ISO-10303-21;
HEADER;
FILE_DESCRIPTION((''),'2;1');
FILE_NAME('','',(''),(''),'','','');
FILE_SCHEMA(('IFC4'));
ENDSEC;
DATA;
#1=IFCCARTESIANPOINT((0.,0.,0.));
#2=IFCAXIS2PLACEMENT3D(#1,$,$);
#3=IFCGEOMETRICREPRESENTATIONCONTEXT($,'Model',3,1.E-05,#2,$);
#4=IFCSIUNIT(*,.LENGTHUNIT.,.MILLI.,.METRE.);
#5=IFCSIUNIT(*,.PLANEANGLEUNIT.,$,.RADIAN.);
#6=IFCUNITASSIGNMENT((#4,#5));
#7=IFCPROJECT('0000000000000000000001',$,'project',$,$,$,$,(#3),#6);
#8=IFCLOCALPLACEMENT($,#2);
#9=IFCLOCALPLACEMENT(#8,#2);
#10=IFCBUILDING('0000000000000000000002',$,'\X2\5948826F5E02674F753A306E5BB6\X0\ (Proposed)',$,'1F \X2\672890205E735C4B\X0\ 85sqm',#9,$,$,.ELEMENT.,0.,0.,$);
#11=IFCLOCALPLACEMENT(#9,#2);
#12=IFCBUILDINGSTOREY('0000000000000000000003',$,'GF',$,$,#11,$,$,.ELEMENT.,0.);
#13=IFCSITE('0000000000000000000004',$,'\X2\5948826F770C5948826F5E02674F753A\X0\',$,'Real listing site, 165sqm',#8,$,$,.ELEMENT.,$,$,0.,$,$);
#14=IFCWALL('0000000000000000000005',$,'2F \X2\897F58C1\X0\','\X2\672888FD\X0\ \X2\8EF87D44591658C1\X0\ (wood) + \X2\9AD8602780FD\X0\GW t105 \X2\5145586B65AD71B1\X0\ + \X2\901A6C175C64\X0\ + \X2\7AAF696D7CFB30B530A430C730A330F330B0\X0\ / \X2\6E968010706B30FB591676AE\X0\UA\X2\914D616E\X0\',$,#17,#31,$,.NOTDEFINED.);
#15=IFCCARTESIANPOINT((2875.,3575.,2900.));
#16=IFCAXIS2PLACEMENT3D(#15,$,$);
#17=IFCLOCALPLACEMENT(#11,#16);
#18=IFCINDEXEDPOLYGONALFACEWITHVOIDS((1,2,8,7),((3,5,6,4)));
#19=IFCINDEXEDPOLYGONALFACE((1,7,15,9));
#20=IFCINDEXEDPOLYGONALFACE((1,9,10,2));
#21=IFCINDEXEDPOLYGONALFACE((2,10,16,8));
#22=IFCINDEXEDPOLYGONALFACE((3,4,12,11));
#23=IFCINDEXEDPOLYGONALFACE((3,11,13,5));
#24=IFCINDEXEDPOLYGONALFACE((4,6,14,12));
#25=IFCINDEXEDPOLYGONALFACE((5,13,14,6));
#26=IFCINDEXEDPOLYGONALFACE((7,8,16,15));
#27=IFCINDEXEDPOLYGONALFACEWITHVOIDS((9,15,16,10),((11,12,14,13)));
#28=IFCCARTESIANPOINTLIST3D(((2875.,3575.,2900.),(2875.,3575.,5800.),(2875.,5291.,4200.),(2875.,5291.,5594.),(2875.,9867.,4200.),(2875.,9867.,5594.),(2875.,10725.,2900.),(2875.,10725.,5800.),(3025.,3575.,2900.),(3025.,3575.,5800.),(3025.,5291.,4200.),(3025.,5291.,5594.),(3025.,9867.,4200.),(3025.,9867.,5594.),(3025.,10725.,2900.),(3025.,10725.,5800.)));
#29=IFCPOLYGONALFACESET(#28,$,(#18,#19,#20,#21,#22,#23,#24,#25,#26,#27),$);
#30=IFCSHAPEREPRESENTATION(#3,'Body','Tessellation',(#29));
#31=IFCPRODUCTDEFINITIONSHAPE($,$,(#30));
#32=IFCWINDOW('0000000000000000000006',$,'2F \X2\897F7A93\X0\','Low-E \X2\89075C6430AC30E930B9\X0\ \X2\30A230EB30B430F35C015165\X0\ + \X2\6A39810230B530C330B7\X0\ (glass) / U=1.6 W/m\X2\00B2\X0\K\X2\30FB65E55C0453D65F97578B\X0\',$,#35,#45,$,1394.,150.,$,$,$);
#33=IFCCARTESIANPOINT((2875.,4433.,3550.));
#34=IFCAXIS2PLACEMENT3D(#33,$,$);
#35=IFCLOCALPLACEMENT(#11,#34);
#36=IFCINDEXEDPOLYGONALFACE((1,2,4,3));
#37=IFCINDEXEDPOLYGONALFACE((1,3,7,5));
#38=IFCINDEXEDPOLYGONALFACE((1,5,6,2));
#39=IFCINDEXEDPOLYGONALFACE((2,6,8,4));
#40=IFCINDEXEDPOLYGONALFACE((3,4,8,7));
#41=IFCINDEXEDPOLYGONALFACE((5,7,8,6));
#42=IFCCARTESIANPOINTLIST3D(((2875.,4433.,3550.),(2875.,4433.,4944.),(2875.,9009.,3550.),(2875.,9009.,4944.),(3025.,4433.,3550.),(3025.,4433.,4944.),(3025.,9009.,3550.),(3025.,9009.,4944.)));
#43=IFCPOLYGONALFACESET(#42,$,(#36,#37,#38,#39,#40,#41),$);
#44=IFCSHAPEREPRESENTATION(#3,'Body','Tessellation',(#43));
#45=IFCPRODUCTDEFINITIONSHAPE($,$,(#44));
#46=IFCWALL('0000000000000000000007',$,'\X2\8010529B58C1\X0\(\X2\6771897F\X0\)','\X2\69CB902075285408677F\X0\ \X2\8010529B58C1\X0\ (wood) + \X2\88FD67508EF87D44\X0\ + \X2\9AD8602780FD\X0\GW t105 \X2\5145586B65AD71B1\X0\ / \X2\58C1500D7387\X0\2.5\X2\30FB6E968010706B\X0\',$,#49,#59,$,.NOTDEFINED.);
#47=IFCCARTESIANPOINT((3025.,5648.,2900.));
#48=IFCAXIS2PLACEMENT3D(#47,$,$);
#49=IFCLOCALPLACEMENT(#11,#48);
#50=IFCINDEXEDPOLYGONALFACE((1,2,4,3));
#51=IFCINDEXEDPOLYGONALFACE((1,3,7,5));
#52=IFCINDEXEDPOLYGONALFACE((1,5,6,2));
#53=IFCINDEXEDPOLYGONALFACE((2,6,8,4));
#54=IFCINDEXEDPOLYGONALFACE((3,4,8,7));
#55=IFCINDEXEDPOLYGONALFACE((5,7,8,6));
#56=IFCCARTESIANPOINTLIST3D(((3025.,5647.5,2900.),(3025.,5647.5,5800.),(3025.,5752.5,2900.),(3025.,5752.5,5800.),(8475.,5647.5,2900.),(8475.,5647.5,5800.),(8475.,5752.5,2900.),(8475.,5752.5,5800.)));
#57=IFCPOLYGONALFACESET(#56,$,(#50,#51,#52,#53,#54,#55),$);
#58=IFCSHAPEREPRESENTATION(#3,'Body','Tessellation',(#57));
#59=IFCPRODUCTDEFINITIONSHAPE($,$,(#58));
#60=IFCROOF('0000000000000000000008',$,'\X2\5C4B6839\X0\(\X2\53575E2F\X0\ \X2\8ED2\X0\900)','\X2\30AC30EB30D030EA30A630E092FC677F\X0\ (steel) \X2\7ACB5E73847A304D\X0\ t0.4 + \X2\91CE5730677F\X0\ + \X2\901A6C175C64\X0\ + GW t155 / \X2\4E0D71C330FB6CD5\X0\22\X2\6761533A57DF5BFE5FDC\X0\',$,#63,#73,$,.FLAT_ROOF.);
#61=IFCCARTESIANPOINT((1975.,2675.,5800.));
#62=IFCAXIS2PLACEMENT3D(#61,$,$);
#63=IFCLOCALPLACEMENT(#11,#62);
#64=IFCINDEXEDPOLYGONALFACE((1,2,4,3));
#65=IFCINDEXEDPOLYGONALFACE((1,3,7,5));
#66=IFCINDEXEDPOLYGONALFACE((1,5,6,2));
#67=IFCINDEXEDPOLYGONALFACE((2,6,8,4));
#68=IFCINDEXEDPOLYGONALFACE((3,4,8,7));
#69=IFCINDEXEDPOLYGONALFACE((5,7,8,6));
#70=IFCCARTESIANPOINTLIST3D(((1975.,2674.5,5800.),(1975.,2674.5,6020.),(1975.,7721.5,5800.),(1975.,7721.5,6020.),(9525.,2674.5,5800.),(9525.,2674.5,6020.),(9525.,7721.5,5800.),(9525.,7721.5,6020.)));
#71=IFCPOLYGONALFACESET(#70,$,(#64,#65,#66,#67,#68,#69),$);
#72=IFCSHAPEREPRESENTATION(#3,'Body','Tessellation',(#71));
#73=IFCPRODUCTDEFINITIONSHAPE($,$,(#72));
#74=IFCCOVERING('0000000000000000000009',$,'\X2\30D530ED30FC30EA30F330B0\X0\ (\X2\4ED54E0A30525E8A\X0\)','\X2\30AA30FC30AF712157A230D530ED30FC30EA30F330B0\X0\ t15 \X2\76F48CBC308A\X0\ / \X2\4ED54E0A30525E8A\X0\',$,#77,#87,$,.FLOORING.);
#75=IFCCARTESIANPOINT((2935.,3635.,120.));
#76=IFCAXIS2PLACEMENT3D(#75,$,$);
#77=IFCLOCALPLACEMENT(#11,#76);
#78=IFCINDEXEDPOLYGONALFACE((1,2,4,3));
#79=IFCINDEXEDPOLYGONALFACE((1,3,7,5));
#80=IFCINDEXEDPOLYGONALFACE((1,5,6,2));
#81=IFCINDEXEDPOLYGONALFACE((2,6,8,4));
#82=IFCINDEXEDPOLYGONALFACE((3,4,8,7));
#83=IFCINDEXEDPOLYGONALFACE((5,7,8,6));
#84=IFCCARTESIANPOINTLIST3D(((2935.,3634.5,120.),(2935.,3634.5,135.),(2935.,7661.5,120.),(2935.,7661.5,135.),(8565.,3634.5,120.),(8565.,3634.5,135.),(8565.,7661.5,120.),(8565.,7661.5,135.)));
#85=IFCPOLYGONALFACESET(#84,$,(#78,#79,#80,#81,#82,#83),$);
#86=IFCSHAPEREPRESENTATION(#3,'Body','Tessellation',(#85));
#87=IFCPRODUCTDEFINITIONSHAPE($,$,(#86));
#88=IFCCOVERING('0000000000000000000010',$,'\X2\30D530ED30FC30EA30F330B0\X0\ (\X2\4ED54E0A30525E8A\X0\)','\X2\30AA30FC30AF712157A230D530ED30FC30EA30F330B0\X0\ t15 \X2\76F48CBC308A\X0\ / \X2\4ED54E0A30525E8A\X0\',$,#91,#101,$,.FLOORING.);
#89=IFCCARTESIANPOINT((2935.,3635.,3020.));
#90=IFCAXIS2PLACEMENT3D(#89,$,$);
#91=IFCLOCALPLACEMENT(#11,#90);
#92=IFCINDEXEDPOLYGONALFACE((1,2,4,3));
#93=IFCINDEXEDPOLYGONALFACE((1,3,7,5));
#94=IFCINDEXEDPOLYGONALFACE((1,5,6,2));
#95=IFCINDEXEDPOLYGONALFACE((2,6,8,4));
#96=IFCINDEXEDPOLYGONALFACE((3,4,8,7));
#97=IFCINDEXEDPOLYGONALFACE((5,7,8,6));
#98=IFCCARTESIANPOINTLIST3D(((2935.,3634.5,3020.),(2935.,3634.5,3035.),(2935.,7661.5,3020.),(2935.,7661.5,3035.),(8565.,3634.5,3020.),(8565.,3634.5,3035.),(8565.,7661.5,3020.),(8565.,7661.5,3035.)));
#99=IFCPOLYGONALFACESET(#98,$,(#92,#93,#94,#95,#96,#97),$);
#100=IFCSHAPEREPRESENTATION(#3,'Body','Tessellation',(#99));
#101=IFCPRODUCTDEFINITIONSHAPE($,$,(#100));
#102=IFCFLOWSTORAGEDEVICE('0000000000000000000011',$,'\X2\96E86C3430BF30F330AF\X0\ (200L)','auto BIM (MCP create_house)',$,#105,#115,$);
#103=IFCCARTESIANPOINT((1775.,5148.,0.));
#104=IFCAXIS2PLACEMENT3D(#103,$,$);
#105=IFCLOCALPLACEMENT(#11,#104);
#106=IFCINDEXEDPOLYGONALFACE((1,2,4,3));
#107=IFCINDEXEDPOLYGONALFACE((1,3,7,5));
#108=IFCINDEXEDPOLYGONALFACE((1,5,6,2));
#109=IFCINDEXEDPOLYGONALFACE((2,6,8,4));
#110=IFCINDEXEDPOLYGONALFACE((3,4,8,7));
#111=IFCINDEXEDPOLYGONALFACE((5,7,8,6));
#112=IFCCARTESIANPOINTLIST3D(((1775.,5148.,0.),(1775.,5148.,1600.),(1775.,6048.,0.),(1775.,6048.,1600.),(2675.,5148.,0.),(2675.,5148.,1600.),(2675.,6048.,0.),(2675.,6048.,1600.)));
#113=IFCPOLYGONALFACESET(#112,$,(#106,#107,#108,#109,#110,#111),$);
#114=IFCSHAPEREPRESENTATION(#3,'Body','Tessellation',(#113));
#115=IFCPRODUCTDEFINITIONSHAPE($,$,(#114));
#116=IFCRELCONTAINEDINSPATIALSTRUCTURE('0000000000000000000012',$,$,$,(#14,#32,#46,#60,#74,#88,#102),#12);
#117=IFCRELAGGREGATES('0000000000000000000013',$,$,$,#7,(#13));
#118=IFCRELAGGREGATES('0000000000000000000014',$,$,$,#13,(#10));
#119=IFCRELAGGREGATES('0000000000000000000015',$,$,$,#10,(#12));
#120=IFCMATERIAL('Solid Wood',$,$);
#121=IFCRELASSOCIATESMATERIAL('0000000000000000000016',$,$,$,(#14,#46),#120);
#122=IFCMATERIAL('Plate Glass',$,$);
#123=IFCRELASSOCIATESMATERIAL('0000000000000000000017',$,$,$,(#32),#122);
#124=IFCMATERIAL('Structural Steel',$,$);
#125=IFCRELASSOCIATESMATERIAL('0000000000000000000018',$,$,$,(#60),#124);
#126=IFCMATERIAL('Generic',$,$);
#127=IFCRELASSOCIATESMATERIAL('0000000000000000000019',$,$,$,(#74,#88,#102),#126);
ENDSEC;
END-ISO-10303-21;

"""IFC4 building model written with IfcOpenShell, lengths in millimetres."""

from ifc_helpers import new_model, si_unit, frame, frame_2d, origin, place, context, project, spatial, rectangle, extrude, material, element, fill, save


model = new_model("IFC4")

# Units and contexts
model_context = context("Model", 3, precision=1e-05, world=origin())
ifc_project = project(units=[si_unit("LENGTHUNIT", "METRE", prefix="MILLI"), si_unit("PLANEANGLEUNIT", "RADIAN")], contexts=[model_context])

# Site, building, storey
site_placement = place(None, origin())
site = spatial("IfcSite", under=ifc_project, at=site_placement, Name="奈良県奈良市杏町", ObjectType="Real listing site, 165sqm", CompositionType="ELEMENT", RefElevation=0.0)
building_placement = place(site_placement, origin())
building = spatial("IfcBuilding", under=site, at=building_placement, Name="奈良市杏町の家 (Proposed)", ObjectType="1F 木造平屋 85sqm", CompositionType="ELEMENT", ElevationOfRefHeight=0.0, ElevationOfTerrain=0.0)
storey_placement = place(building_placement, origin())
storey = spatial("IfcBuildingStorey", under=building, at=storey_placement, Name="GF", CompositionType="ELEMENT", Elevation=0.0)

# Shared definitions
ifc_material_1 = material(Name="Solid Wood")
ifc_material_2 = material(Name="Generic")

# Shared definitions
ifc_material_3 = material(Name="Plate Glass")

# Wall, opening, window
wall_1_placement = place(storey_placement, frame((2875.0, 3575.0, 2900.0)))
wall_1 = element("IfcWall", 1, at=wall_1_placement, inside=storey, material=ifc_material_1, Name="2F 西壁", Description="木製 軸組外壁 (wood) + 高性能GW t105 充填断熱 + 通気層 + 窯業系サイディング / 準耐火・外皮UA配慮", PredefinedType="NOTDEFINED", context=model_context, shape_type="SweptSolid", body=[
    extrude(rectangle(XDim=150.0, YDim=7150.0, at=frame_2d((75.0, 3575.0))), frame((2875.0, 3575.0, 2900.0)), (0.0, 0.0, 1.0), 2900.0),
])
opening_1_placement = place(storey_placement, frame((2875.0, 4433.0, 3550.0)))
opening_1 = element("IfcOpeningElement", 2, at=opening_1_placement, cuts=wall_1, PredefinedType="NOTDEFINED", context=model_context, shape_type="SweptSolid", body=[
    extrude(rectangle(XDim=150.0, YDim=4576.0, at=frame_2d((75.0, 2288.0))), frame((2875.0, 4433.0, 3550.0)), (0.0, 0.0, 1.0), 1394.0),
])
window_1_placement = place(storey_placement, frame((2875.0, 4433.0, 3550.0)))
window_1 = element("IfcWindow", 3, at=window_1_placement, inside=storey, material=ifc_material_3, Name="2F 西窓", Description="Low-E 複層ガラス アルゴン封入 + 樹脂サッシ (glass) / U=1.6 W/m²K・日射取得型", OverallHeight=1394.0, OverallWidth=150.0, context=model_context, shape_type="SweptSolid", body=[
    extrude(rectangle(XDim=150.0, YDim=4576.0, at=frame_2d((75.0, 2288.0))), frame((2875.0, 4433.0, 3550.0)), (0.0, 0.0, 1.0), 1394.0),
])
fill(opening_1, window_1)

# Wall
wall_2_placement = place(storey_placement, frame((3025.0, 5648.0, 2900.0)))
element("IfcWall", 4, at=wall_2_placement, inside=storey, material=ifc_material_1, Name="耐力壁(東西)", Description="構造用合板 耐力壁 (wood) + 製材軸組 + 高性能GW t105 充填断熱 / 壁倍率2.5・準耐火", PredefinedType="NOTDEFINED", context=model_context, shape_type="SweptSolid", body=[
    extrude(rectangle(XDim=5450.0, YDim=105.0, at=frame_2d((2725.0, 52.0))), frame((3025.0, 5648.0, 2900.0)), (0.0, 0.0, 1.0), 2900.0),
])

# Roof
ifc_material_4 = material(Name="Structural Steel")
for number, where, name in (
    (5, (1975.0, 2675.0, 5800.0), "屋根(南帯 軒900)"),
):
    element("IfcRoof", number, at=place(storey_placement, frame(where)), inside=storey, material=ifc_material_4, Name=name, Description="ガルバリウム鋼板 (steel) 立平葺き t0.4 + 野地板 + 通気層 + GW t155 / 不燃・法22条区域対応", PredefinedType="FLAT_ROOF", context=model_context, shape_type="SweptSolid", body=[
        extrude(rectangle(XDim=7550.0, YDim=5047.0, at=frame_2d((3775.0, 2523.0))), frame((1975.0, 2675.0, 5800.0)), (0.0, 0.0, 1.0), 220.0),
    ])

# Coverings
covering_1_placement = place(storey_placement, frame((2935.0, 3635.0, 120.0)))
element("IfcCovering", 6, at=covering_1_placement, inside=storey, material=ifc_material_2, Name="フローリング (仕上げ床)", Description="オーク無垢フローリング t15 直貼り / 仕上げ床", PredefinedType="FLOORING", context=model_context, shape_type="SweptSolid", body=[
    extrude(rectangle(XDim=5630.0, YDim=4027.0, at=frame_2d((2815.0, 2013.0))), frame((2935.0, 3635.0, 120.0)), (0.0, 0.0, 1.0), 15.0),
])
covering_2_placement = place(storey_placement, frame((2935.0, 3635.0, 3020.0)))
element("IfcCovering", 7, at=covering_2_placement, inside=storey, material=ifc_material_2, Name="フローリング (仕上げ床)", Description="オーク無垢フローリング t15 直貼り / 仕上げ床", PredefinedType="FLOORING", context=model_context, shape_type="SweptSolid", body=[
    extrude(rectangle(XDim=5630.0, YDim=4027.0, at=frame_2d((2815.0, 2013.0))), frame((2935.0, 3635.0, 3020.0)), (0.0, 0.0, 1.0), 15.0),
])

# Flow storage device
flow_storage_device_placement = place(storey_placement, frame((1775.0, 5148.0, 0.0)))
element("IfcFlowStorageDevice", 8, at=flow_storage_device_placement, inside=storey, material=ifc_material_2, Name="雨水タンク (200L)", Description="auto BIM (MCP create_house)", context=model_context, shape_type="SweptSolid", body=[
    extrude(rectangle(XDim=900.0, YDim=900.0, at=frame_2d((450.0, 450.0))), frame((1775.0, 5148.0, 0.0)), (0.0, 0.0, 1.0), 1600.0),
])

save(model, "model.ifc")
